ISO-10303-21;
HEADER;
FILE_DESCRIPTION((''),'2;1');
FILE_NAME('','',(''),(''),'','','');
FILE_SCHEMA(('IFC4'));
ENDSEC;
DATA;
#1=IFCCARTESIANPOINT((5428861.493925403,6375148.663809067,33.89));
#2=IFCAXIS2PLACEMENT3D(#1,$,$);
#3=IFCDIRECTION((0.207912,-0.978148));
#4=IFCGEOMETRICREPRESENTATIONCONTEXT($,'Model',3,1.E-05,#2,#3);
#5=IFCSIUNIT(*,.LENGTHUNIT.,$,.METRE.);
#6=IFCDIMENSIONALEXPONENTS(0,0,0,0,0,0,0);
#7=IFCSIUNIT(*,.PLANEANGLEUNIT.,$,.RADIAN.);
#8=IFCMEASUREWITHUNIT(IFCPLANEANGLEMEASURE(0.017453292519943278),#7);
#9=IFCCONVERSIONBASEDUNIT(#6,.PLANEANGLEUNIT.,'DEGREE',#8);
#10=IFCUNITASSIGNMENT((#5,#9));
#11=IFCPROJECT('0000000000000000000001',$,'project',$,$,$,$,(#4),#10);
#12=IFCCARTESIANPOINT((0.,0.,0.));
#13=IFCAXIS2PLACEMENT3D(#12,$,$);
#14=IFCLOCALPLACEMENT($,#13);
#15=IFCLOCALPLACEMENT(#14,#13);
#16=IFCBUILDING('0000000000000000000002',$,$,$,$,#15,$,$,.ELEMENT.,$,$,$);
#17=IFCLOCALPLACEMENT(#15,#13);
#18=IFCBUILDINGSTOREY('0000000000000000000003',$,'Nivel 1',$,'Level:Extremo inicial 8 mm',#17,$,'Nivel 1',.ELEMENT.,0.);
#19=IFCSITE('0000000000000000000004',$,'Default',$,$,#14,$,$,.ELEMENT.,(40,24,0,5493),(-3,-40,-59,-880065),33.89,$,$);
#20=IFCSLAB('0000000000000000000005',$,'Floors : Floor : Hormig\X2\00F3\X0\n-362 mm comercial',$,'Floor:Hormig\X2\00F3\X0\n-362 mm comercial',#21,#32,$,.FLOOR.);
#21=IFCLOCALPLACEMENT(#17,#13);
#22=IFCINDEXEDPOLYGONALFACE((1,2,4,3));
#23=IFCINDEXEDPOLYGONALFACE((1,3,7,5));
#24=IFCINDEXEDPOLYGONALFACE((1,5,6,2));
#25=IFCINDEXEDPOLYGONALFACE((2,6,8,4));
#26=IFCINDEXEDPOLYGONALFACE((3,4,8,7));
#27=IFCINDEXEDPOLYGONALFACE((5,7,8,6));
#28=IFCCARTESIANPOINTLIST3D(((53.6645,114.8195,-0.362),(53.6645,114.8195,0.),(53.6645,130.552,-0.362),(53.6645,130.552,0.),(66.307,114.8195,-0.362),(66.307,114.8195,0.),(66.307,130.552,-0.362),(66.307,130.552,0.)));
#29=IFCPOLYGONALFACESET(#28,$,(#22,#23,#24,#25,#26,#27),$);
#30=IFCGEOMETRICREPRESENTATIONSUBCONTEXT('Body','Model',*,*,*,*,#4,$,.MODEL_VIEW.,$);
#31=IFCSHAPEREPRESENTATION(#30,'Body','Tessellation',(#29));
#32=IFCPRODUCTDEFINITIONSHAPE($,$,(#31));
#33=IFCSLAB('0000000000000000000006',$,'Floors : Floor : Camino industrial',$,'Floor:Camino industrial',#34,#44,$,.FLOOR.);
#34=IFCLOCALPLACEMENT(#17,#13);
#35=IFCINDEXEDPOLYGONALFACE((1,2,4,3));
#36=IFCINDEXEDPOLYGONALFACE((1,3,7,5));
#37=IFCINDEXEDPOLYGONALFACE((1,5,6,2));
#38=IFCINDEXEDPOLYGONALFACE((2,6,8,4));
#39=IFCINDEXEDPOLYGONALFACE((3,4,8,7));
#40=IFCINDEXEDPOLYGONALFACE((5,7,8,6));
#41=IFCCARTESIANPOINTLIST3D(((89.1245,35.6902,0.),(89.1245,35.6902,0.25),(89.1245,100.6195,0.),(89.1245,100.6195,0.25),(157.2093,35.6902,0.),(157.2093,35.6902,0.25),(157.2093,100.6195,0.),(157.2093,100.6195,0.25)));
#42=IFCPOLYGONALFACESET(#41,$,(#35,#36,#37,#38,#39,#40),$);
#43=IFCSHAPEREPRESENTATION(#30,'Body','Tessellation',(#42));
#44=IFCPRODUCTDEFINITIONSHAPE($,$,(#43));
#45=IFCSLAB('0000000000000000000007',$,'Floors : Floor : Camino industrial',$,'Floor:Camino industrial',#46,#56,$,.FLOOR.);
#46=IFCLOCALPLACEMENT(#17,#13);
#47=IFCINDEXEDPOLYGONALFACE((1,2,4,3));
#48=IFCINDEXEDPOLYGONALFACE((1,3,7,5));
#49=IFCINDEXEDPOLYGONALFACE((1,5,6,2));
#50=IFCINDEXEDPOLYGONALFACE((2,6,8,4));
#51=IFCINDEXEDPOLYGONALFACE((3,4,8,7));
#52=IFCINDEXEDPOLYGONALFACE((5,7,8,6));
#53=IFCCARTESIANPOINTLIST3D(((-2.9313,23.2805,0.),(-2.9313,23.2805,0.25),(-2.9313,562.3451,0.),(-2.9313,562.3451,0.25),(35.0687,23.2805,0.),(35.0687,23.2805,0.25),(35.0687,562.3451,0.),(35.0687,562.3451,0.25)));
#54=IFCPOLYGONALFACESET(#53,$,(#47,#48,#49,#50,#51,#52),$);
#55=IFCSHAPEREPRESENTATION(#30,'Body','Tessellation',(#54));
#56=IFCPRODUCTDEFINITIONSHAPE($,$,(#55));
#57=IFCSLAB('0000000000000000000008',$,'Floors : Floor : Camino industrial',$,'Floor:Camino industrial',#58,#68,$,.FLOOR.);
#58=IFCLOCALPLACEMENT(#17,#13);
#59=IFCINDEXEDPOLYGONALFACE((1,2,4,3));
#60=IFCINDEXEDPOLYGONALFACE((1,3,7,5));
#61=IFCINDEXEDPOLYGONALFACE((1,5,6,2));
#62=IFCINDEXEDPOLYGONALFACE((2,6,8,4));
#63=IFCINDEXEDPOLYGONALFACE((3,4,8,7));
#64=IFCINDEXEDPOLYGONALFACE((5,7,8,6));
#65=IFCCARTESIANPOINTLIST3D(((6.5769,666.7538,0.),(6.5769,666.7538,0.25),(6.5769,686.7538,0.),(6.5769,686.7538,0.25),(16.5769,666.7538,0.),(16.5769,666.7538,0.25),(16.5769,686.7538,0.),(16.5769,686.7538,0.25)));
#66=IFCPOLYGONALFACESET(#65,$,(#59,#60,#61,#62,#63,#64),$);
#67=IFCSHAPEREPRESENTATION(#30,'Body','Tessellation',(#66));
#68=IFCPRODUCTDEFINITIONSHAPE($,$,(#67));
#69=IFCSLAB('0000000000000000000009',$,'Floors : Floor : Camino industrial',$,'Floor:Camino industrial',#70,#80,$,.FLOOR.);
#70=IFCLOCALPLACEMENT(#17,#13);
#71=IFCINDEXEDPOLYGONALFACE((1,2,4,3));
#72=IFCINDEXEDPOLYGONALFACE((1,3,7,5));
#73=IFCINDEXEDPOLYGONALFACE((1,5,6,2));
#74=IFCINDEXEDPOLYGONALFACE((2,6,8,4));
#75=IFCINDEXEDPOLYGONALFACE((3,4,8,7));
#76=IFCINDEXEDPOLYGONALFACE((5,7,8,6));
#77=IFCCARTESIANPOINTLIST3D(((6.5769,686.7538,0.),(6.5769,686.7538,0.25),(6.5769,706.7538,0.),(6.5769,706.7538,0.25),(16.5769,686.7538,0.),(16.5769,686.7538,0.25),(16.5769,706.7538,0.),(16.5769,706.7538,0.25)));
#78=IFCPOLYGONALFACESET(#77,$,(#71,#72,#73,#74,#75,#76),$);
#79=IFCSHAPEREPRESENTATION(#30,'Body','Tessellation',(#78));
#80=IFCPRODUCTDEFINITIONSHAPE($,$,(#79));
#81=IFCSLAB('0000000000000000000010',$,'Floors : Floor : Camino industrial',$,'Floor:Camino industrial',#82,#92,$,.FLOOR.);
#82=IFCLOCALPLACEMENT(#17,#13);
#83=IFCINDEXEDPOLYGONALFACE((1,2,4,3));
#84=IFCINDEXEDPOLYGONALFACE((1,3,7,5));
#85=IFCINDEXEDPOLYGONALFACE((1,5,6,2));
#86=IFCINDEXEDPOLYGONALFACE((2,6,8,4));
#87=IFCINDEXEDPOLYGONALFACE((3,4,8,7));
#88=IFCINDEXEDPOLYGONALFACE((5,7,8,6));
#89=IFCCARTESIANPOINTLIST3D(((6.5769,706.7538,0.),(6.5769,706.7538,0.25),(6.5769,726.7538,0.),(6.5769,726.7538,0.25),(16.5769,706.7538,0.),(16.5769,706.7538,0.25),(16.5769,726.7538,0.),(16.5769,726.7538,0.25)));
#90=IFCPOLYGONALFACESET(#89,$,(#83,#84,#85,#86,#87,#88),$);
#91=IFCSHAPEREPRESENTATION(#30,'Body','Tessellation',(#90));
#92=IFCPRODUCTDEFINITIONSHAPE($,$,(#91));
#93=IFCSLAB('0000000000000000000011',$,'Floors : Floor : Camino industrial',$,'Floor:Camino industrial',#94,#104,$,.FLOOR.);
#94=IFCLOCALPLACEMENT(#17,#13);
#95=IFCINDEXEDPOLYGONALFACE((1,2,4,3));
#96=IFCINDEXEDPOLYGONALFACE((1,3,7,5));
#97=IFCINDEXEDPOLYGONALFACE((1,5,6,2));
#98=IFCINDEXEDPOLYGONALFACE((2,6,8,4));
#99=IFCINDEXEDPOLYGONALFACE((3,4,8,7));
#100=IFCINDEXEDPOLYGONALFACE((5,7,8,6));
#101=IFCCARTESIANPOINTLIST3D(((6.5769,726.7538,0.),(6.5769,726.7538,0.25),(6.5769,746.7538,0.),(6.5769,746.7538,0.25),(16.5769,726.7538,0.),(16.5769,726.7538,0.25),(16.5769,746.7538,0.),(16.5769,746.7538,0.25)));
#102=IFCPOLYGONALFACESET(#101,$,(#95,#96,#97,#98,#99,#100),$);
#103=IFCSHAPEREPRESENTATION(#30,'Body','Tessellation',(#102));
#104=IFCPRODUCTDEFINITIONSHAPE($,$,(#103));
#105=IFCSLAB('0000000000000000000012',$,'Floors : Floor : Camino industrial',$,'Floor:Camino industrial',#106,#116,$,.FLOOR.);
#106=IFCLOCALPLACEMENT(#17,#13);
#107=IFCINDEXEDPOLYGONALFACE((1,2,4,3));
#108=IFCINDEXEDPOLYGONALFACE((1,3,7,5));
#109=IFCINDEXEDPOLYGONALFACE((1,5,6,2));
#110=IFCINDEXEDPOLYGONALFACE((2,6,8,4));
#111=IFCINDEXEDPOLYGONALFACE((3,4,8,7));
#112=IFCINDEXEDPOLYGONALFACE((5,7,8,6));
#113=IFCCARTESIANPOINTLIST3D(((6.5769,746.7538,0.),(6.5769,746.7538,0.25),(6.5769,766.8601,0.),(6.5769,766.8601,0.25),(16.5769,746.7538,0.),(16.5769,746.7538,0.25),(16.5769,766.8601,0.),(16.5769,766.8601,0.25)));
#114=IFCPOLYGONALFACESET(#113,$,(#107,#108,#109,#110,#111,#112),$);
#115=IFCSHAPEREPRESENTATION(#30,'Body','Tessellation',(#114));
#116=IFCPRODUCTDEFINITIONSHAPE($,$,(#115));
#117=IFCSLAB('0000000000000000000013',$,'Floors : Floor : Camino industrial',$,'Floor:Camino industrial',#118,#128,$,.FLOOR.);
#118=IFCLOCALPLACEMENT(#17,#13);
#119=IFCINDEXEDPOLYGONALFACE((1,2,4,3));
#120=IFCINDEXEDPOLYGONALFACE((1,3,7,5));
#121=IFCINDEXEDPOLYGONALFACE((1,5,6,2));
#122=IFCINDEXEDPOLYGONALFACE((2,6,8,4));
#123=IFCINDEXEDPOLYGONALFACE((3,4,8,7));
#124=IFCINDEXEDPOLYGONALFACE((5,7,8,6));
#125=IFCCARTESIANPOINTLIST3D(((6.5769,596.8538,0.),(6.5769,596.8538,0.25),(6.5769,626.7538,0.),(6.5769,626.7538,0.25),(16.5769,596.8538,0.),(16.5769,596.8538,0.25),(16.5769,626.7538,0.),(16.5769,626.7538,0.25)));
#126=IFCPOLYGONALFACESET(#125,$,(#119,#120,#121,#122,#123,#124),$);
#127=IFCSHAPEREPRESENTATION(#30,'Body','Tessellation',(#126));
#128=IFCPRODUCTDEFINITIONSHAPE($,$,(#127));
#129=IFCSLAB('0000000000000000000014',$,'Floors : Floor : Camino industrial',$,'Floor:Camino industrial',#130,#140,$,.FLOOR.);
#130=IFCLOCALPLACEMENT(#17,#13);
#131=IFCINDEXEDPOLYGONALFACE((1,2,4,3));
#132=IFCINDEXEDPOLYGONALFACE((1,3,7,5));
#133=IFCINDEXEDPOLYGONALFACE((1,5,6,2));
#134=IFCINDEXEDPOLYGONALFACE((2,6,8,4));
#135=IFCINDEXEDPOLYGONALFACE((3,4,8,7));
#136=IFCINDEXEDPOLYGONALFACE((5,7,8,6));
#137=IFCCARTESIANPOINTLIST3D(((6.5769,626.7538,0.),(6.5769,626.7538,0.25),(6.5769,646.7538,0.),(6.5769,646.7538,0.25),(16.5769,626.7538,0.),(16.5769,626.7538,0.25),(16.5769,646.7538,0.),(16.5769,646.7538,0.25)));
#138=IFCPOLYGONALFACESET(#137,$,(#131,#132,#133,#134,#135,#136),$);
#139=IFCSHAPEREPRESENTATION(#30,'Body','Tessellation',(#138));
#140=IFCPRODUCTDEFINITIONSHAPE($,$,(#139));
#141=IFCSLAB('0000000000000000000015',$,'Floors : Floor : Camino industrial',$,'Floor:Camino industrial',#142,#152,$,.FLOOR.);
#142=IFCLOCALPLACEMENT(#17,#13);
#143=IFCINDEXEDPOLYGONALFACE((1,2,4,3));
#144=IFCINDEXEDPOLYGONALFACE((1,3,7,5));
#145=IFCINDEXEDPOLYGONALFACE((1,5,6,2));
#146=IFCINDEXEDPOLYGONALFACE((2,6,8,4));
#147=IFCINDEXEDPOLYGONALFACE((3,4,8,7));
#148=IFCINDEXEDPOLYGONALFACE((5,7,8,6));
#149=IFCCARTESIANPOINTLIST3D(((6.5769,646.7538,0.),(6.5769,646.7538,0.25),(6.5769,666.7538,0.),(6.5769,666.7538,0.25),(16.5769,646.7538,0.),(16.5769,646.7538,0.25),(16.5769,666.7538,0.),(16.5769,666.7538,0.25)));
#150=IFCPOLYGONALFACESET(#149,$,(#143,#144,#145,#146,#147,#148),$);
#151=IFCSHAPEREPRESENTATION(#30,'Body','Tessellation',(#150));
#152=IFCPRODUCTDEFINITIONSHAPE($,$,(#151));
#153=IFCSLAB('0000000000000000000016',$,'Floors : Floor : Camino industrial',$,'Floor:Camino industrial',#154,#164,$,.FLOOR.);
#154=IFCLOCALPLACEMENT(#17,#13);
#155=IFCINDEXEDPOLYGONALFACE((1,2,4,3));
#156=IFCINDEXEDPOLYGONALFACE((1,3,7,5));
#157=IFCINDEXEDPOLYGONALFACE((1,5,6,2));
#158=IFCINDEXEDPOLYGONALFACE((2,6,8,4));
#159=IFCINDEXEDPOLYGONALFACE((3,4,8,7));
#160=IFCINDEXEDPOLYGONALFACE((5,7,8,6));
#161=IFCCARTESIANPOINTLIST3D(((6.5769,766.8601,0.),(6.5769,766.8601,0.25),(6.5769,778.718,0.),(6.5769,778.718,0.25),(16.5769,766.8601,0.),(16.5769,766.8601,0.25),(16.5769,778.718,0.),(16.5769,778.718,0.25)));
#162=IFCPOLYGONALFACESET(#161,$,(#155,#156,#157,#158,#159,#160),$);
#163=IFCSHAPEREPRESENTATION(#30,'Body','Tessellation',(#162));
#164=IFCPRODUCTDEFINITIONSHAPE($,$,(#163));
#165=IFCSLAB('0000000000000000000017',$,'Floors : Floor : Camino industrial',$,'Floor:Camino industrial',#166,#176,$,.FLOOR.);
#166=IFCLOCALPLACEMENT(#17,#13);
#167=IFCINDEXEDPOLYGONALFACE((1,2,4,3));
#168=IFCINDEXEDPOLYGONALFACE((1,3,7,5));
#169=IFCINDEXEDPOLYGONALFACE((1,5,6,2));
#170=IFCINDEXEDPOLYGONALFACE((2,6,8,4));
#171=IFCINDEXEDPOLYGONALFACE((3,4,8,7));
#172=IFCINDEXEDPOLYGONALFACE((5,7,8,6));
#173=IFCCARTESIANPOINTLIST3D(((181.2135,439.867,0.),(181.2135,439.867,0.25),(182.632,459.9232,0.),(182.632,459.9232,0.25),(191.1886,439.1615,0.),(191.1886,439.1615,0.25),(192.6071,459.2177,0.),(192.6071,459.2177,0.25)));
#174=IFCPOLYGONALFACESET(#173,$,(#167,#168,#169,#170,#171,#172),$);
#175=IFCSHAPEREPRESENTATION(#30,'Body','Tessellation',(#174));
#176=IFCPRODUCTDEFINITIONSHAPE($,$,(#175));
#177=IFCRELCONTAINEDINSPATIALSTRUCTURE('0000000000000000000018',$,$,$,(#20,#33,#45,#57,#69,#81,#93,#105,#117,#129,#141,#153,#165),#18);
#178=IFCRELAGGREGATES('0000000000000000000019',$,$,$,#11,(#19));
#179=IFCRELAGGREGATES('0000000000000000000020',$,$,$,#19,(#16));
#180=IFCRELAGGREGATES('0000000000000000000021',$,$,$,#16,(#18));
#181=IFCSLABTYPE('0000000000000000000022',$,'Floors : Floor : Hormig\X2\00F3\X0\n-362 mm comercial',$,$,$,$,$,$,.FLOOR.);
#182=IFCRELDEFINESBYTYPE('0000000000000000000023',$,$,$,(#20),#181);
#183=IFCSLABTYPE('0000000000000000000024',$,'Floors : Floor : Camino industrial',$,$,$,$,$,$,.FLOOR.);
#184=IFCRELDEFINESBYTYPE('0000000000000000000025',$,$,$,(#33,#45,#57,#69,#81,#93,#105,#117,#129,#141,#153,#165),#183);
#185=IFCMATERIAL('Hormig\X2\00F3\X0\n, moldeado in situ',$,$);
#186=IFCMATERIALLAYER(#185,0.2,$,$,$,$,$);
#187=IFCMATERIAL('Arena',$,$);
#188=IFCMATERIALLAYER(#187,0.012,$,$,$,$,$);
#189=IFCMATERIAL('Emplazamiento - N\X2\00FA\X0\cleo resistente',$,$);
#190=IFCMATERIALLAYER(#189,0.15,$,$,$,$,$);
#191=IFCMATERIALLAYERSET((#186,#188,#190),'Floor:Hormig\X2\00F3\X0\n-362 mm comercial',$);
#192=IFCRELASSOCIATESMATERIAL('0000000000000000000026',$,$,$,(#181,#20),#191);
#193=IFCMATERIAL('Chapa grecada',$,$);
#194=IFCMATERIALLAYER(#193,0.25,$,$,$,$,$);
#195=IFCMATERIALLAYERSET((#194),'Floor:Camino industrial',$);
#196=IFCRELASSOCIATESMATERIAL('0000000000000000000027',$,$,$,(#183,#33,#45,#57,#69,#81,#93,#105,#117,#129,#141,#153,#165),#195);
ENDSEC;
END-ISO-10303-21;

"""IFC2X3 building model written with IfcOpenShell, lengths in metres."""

from ifc_helpers import new_model, entity, si_unit, converted_unit, direction, frame, frame_2d, origin, origin_2d_with_axis, place, context, subcontext, project, spatial, rectangle, extrude, material, layer, layer_set, layer_usage, type_object, element, save


model = new_model("IFC2X3")

# Units and contexts
model_context = context("Model", 3, precision=1e-05, world=frame((5428861.493925403, 6375148.663809067, 33.89)), true_north=direction((0.207912, -0.978148)))
body_context = subcontext(model_context, "Body", "Model", "MODEL_VIEW")
ifc_project = project(units=[si_unit("LENGTHUNIT", "METRE"), converted_unit("PLANEANGLEUNIT", "DEGREE", entity("IfcPlaneAngleMeasure", 0.017453292519943278), si_unit("PLANEANGLEUNIT", "RADIAN"), dimensions=[0, 0, 0, 0, 0, 0, 0])], contexts=[model_context])

# Site, building, storey
site_placement = place(None, origin())
site = spatial("IfcSite", under=ifc_project, at=site_placement, Name="Default", CompositionType="ELEMENT", RefLatitude=(40, 24, 0, 5493), RefLongitude=(-3, -40, -59, -880065), RefElevation=33.89)
building_placement = place(site_placement, origin())
building = spatial("IfcBuilding", under=site, at=building_placement, CompositionType="ELEMENT")
storey_placement = place(building_placement, origin())
storey = spatial("IfcBuildingStorey", under=building, at=storey_placement, Name="Nivel 1", ObjectType="Level:Extremo inicial 8 mm", LongName="Nivel 1", CompositionType="ELEMENT", Elevation=0.0)

# Slabs
ifc_material_1 = material(Name="Hormigón, moldeado in situ")
ifc_layer_1 = layer(ifc_material_1, 0.2)
ifc_material_2 = material(Name="Arena")
ifc_layer_2 = layer(ifc_material_2, 0.012)
ifc_material_3 = material(Name="Emplazamiento - Núcleo resistente")
ifc_layer_3 = layer(ifc_material_3, 0.15)
ifc_layer_set_1 = layer_set([ifc_layer_1, ifc_layer_2, ifc_layer_3], Name="Floor:Hormigón-362 mm comercial")
ifc_layer_usage_1 = layer_usage(ifc_layer_set_1, "AXIS3", "POSITIVE", 0.0)
slab_type_1 = type_object("IfcSlabType", Name="Floors : Floor : Hormigón-362 mm comercial", PredefinedType="FLOOR", material=ifc_layer_set_1)
slab_1_placement = place(storey_placement, origin())
element("IfcSlab", 1, at=slab_1_placement, inside=storey, type_object=slab_type_1, material=ifc_layer_usage_1, Name="Floors : Floor : Hormigón-362 mm comercial", ObjectType="Floor:Hormigón-362 mm comercial", PredefinedType="FLOOR", context=body_context, shape_type="SweptSolid", body=[
    extrude(rectangle(XDim=15.7325, YDim=12.6425, at=frame_2d((0.0, 0.0), x_axis=(1.0, 0.0))), frame((59.9857, 122.6858, 0.0), z_axis=(0.0, 0.0, -1.0), x_axis=(0.0, 1.0, 0.0)), (0.0, 0.0, 1.0), 0.362),
])
ifc_material_4 = material(Name="Chapa grecada")
ifc_layer_4 = layer(ifc_material_4, 0.25)
ifc_layer_set_2 = layer_set([ifc_layer_4], Name="Floor:Camino industrial")
ifc_layer_usage_2 = layer_usage(ifc_layer_set_2, "AXIS3", "POSITIVE", 0.0)
slab_type_2 = type_object("IfcSlabType", Name="Floors : Floor : Camino industrial", PredefinedType="FLOOR", material=ifc_layer_set_2)
slab_2_placement = place(storey_placement, origin())
element("IfcSlab", 2, at=slab_2_placement, inside=storey, type_object=slab_type_2, material=ifc_layer_usage_2, Name="Floors : Floor : Camino industrial", ObjectType="Floor:Camino industrial", PredefinedType="FLOOR", context=body_context, shape_type="SweptSolid", body=[
    extrude(rectangle(XDim=64.9293, YDim=68.0848, at=frame_2d((0.0, 0.0), x_axis=(1.0, 0.0))), frame((123.1669, 68.1548, 0.25), z_axis=(0.0, 0.0, -1.0), x_axis=(0.0, 1.0, 0.0)), (0.0, 0.0, 1.0), 0.25),
])
ifc_layer_usage_3 = layer_usage(ifc_layer_set_2, "AXIS3", "POSITIVE", 0.0)
slab_3_placement = place(storey_placement, origin())
element("IfcSlab", 3, at=slab_3_placement, inside=storey, type_object=slab_type_2, material=ifc_layer_usage_3, Name="Floors : Floor : Camino industrial", ObjectType="Floor:Camino industrial", PredefinedType="FLOOR", context=body_context, shape_type="SweptSolid", body=[
    extrude(rectangle(XDim=539.0645, YDim=38.0, at=origin_2d_with_axis()), frame((16.0687, 292.8128, 0.25), z_axis=(0.0, 0.0, -1.0), x_axis=(0.0, 1.0, 0.0)), (0.0, 0.0, 1.0), 0.25),
])
ifc_layer_usage_4 = layer_usage(ifc_layer_set_2, "AXIS3", "POSITIVE", 0.0)
slab_4_placement = place(storey_placement, origin())
element("IfcSlab", 4, at=slab_4_placement, inside=storey, type_object=slab_type_2, material=ifc_layer_usage_4, Name="Floors : Floor : Camino industrial", ObjectType="Floor:Camino industrial", PredefinedType="FLOOR", context=body_context, shape_type="SweptSolid", body=[
    extrude(rectangle(XDim=20.0, YDim=10.0, at=origin_2d_with_axis()), frame((11.5769, 676.7538, 0.25), z_axis=(0.0, 0.0, -1.0), x_axis=(0.0, 1.0, 0.0)), (0.0, 0.0, 1.0), 0.25),
])
ifc_layer_usage_5 = layer_usage(ifc_layer_set_2, "AXIS3", "POSITIVE", 0.0)
slab_5_placement = place(storey_placement, origin())
element("IfcSlab", 5, at=slab_5_placement, inside=storey, type_object=slab_type_2, material=ifc_layer_usage_5, Name="Floors : Floor : Camino industrial", ObjectType="Floor:Camino industrial", PredefinedType="FLOOR", context=body_context, shape_type="SweptSolid", body=[
    extrude(rectangle(XDim=20.0, YDim=10.0, at=frame_2d((0.0, 0.0), x_axis=(1.0, 0.0))), frame((11.5769, 696.7538, 0.25), z_axis=(0.0, 0.0, -1.0), x_axis=(0.0, 1.0, 0.0)), (0.0, 0.0, 1.0), 0.25),
])
ifc_layer_usage_6 = layer_usage(ifc_layer_set_2, "AXIS3", "POSITIVE", 0.0)
slab_6_placement = place(storey_placement, origin())
element("IfcSlab", 6, at=slab_6_placement, inside=storey, type_object=slab_type_2, material=ifc_layer_usage_6, Name="Floors : Floor : Camino industrial", ObjectType="Floor:Camino industrial", PredefinedType="FLOOR", context=body_context, shape_type="SweptSolid", body=[
    extrude(rectangle(XDim=20.0, YDim=10.0, at=frame_2d((0.0, 0.0), x_axis=(1.0, 0.0))), frame((11.5769, 716.7538, 0.25), z_axis=(0.0, 0.0, -1.0), x_axis=(0.0, 1.0, 0.0)), (0.0, 0.0, 1.0), 0.25),
])
ifc_layer_usage_7 = layer_usage(ifc_layer_set_2, "AXIS3", "POSITIVE", 0.0)
slab_7_placement = place(storey_placement, origin())
element("IfcSlab", 7, at=slab_7_placement, inside=storey, type_object=slab_type_2, material=ifc_layer_usage_7, Name="Floors : Floor : Camino industrial", ObjectType="Floor:Camino industrial", PredefinedType="FLOOR", context=body_context, shape_type="SweptSolid", body=[
    extrude(rectangle(XDim=20.0, YDim=10.0, at=frame_2d((0.0, 0.0), x_axis=(1.0, 0.0))), frame((11.5769, 736.7538, 0.25), z_axis=(0.0, 0.0, -1.0), x_axis=(0.0, 1.0, 0.0)), (0.0, 0.0, 1.0), 0.25),
])
ifc_layer_usage_8 = layer_usage(ifc_layer_set_2, "AXIS3", "POSITIVE", 0.0)
slab_8_placement = place(storey_placement, origin())
element("IfcSlab", 8, at=slab_8_placement, inside=storey, type_object=slab_type_2, material=ifc_layer_usage_8, Name="Floors : Floor : Camino industrial", ObjectType="Floor:Camino industrial", PredefinedType="FLOOR", context=body_context, shape_type="SweptSolid", body=[
    extrude(rectangle(XDim=20.1063, YDim=10.0, at=origin_2d_with_axis()), frame((11.5769, 756.8069, 0.25), z_axis=(0.0, 0.0, -1.0), x_axis=(0.0, 1.0, 0.0)), (0.0, 0.0, 1.0), 0.25),
])
ifc_layer_usage_9 = layer_usage(ifc_layer_set_2, "AXIS3", "POSITIVE", 0.0)
slab_9_placement = place(storey_placement, origin())
element("IfcSlab", 9, at=slab_9_placement, inside=storey, type_object=slab_type_2, material=ifc_layer_usage_9, Name="Floors : Floor : Camino industrial", ObjectType="Floor:Camino industrial", PredefinedType="FLOOR", context=body_context, shape_type="SweptSolid", body=[
    extrude(rectangle(XDim=29.9, YDim=10.0, at=origin_2d_with_axis()), frame((11.5769, 611.8038, 0.25), z_axis=(0.0, 0.0, -1.0), x_axis=(0.0, 1.0, 0.0)), (0.0, 0.0, 1.0), 0.25),
])
ifc_layer_usage_10 = layer_usage(ifc_layer_set_2, "AXIS3", "POSITIVE", 0.0)
slab_10_placement = place(storey_placement, origin())
element("IfcSlab", 10, at=slab_10_placement, inside=storey, type_object=slab_type_2, material=ifc_layer_usage_10, Name="Floors : Floor : Camino industrial", ObjectType="Floor:Camino industrial", PredefinedType="FLOOR", context=body_context, shape_type="SweptSolid", body=[
    extrude(rectangle(XDim=20.0, YDim=10.0, at=origin_2d_with_axis()), frame((11.5769, 636.7538, 0.25), z_axis=(0.0, 0.0, -1.0), x_axis=(0.0, 1.0, 0.0)), (0.0, 0.0, 1.0), 0.25),
])
ifc_layer_usage_11 = layer_usage(ifc_layer_set_2, "AXIS3", "POSITIVE", 0.0)
slab_11_placement = place(storey_placement, origin())
element("IfcSlab", 11, at=slab_11_placement, inside=storey, type_object=slab_type_2, material=ifc_layer_usage_11, Name="Floors : Floor : Camino industrial", ObjectType="Floor:Camino industrial", PredefinedType="FLOOR", context=body_context, shape_type="SweptSolid", body=[
    extrude(rectangle(XDim=20.0, YDim=10.0, at=origin_2d_with_axis()), frame((11.5769, 656.7538, 0.25), z_axis=(0.0, 0.0, -1.0), x_axis=(0.0, 1.0, 0.0)), (0.0, 0.0, 1.0), 0.25),
])
ifc_layer_usage_12 = layer_usage(ifc_layer_set_2, "AXIS3", "POSITIVE", 0.0)
slab_12_placement = place(storey_placement, origin())
element("IfcSlab", 12, at=slab_12_placement, inside=storey, type_object=slab_type_2, material=ifc_layer_usage_12, Name="Floors : Floor : Camino industrial", ObjectType="Floor:Camino industrial", PredefinedType="FLOOR", context=body_context, shape_type="SweptSolid", body=[
    extrude(rectangle(XDim=11.8579, YDim=10.0, at=frame_2d((0.0, 0.0), x_axis=(1.0, 0.0))), frame((11.5769, 772.789, 0.25), z_axis=(0.0, 0.0, -1.0), x_axis=(0.0, 1.0, 0.0)), (0.0, 0.0, 1.0), 0.25),
])
ifc_layer_usage_13 = layer_usage(ifc_layer_set_2, "AXIS3", "POSITIVE", 0.0)
slab_13_placement = place(storey_placement, origin())
element("IfcSlab", 13, at=slab_13_placement, inside=storey, type_object=slab_type_2, material=ifc_layer_usage_13, Name="Floors : Floor : Camino industrial", ObjectType="Floor:Camino industrial", PredefinedType="FLOOR", context=body_context, shape_type="SweptSolid", body=[
    extrude(rectangle(XDim=20.1063, YDim=10.0, at=frame_2d((0.0, 0.0), x_axis=(1.0, 0.0))), frame((186.9103, 449.5424, 0.25), z_axis=(0.0, 0.0, -1.0), x_axis=(-0.070551, -0.997508, 0.0)), (0.0, 0.0, 1.0), 0.25),
])

save(model, "model.ifc")
